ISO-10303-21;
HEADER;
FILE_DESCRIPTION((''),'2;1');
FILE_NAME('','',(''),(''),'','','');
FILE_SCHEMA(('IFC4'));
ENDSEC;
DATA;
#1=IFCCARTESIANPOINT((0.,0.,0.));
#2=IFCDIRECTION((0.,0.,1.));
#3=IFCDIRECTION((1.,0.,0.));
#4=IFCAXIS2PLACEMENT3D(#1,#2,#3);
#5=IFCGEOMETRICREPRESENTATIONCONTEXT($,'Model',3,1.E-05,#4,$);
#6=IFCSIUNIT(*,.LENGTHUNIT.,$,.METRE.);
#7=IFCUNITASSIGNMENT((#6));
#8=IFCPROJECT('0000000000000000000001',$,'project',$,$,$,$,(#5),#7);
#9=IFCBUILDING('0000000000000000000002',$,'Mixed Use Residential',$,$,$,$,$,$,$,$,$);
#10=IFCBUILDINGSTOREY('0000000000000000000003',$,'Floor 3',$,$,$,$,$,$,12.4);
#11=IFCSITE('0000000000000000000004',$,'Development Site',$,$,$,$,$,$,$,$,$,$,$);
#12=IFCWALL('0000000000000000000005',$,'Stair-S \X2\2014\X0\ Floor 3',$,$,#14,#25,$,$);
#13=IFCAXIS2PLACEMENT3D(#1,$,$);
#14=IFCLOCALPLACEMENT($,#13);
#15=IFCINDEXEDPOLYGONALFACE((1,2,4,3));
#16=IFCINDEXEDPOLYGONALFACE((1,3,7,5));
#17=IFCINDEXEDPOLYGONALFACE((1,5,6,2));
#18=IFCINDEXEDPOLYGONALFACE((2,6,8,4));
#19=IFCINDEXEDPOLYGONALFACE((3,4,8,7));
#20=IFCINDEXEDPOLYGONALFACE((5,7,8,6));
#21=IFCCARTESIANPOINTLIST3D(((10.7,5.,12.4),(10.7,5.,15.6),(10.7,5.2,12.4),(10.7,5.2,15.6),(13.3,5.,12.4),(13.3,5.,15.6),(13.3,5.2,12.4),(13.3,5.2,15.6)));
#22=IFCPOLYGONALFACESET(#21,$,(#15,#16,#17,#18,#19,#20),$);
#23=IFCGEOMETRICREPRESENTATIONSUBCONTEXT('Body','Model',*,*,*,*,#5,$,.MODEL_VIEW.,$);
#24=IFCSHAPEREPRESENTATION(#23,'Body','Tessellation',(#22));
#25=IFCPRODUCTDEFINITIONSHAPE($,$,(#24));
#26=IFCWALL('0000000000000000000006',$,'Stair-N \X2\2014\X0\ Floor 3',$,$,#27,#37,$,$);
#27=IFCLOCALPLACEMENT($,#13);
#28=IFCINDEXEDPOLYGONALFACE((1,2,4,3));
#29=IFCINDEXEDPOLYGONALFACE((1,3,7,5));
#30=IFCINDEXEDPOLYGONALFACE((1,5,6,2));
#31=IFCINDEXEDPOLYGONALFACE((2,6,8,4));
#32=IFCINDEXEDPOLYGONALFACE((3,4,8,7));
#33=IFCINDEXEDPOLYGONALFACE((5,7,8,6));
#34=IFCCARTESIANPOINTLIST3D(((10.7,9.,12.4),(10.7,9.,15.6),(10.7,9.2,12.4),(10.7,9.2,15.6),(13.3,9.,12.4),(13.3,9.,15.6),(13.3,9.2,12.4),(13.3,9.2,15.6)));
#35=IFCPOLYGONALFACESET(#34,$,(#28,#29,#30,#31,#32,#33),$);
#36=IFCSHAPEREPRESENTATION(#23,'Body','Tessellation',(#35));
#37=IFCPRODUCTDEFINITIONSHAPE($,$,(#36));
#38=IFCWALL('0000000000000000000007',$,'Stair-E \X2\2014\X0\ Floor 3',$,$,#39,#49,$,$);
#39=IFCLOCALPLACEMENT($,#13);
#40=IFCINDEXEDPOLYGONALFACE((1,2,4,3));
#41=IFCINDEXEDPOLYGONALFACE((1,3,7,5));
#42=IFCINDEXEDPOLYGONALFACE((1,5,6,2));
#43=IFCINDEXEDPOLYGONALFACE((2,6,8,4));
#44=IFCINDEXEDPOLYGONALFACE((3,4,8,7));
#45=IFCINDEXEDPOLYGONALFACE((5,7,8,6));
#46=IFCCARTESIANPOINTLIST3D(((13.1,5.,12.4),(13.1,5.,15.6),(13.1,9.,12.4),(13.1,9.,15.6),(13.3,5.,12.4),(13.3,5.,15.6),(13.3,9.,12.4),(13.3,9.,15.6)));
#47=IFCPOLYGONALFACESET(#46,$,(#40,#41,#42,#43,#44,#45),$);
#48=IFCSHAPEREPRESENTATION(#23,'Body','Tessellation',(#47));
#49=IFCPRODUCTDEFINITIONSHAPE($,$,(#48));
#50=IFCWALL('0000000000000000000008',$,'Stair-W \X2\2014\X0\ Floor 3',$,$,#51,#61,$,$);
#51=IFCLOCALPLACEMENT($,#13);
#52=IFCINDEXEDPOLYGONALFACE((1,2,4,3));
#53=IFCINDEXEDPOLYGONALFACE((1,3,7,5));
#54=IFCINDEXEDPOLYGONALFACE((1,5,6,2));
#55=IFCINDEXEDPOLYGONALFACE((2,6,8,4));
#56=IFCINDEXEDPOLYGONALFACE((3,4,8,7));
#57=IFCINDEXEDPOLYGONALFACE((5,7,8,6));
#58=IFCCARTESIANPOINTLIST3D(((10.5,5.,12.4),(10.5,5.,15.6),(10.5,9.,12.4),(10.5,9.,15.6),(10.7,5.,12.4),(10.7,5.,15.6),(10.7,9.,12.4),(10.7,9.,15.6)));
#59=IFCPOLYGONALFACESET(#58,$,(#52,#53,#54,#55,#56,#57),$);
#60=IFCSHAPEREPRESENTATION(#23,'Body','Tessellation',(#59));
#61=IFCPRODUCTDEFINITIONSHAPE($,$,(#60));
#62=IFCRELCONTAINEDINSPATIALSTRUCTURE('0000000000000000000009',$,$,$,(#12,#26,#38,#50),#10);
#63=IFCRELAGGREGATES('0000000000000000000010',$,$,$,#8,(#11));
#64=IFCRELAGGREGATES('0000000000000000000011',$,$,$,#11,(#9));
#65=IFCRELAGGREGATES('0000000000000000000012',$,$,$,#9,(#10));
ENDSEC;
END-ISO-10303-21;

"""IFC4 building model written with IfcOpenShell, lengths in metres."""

from ifc_helpers import new_model, si_unit, frame, origin_with_axes, place, context, subcontext, project, spatial, indexed_curve, outline, extrude, element, save


model = new_model("IFC4")

# Units and contexts
model_context = context("Model", 3, precision=1e-05, world=origin_with_axes())
body_context = subcontext(model_context, "Body", "Model", "MODEL_VIEW")
ifc_project = project(units=[si_unit("LENGTHUNIT", "METRE")], contexts=[model_context])

# Site, building, storey
site = spatial("IfcSite", under=ifc_project, Name="Development Site")
building = spatial("IfcBuilding", under=site, Name="Mixed Use Residential")
storey = spatial("IfcBuildingStorey", under=building, Name="Floor 3", Elevation=12.4)

# Walls
for number, where, z_axis, x_axis, name in (
    (1, (10.7, 5.0, 12.4), (0.0, 0.0, 1.0), (1.0, 0.0, 0.0), "Stair-S — Floor 3"),
    (2, (10.7, 9.0, 12.4), (0.0, 0.0, 1.0), (1.0, 0.0, 0.0), "Stair-N — Floor 3"),
):
    element("IfcWall", number, at=place(None, frame(where, z_axis=z_axis, x_axis=x_axis)), inside=storey, Name=name, context=body_context, shape_type="SweptSolid", body=[
        extrude(outline(indexed_curve([(0.0, 0.0), (0.0, 0.2), (2.6, 0.2), (2.6, 0.0), (0.0, 0.0)], self_intersect=False)), origin_with_axes(), (0.0, 0.0, 1.0), 3.2),
    ])
for number, where, z_axis, x_axis, name in (
    (3, (13.3, 5.0, 12.4), (0.0, 0.0, 1.0), (0.0, 1.0, 0.0), "Stair-E — Floor 3"),
    (4, (10.7, 5.0, 12.4), (0.0, 0.0, 1.0), (0.0, 1.0, 0.0), "Stair-W — Floor 3"),
):
    element("IfcWall", number, at=place(None, frame(where, z_axis=z_axis, x_axis=x_axis)), inside=storey, Name=name, context=body_context, shape_type="SweptSolid", body=[
        extrude(outline(indexed_curve([(0.0, 0.0), (0.0, 0.2), (4.0, 0.2), (4.0, 0.0), (0.0, 0.0)], self_intersect=False)), origin_with_axes(), (0.0, 0.0, 1.0), 3.2),
    ])

save(model, "model.ifc")
